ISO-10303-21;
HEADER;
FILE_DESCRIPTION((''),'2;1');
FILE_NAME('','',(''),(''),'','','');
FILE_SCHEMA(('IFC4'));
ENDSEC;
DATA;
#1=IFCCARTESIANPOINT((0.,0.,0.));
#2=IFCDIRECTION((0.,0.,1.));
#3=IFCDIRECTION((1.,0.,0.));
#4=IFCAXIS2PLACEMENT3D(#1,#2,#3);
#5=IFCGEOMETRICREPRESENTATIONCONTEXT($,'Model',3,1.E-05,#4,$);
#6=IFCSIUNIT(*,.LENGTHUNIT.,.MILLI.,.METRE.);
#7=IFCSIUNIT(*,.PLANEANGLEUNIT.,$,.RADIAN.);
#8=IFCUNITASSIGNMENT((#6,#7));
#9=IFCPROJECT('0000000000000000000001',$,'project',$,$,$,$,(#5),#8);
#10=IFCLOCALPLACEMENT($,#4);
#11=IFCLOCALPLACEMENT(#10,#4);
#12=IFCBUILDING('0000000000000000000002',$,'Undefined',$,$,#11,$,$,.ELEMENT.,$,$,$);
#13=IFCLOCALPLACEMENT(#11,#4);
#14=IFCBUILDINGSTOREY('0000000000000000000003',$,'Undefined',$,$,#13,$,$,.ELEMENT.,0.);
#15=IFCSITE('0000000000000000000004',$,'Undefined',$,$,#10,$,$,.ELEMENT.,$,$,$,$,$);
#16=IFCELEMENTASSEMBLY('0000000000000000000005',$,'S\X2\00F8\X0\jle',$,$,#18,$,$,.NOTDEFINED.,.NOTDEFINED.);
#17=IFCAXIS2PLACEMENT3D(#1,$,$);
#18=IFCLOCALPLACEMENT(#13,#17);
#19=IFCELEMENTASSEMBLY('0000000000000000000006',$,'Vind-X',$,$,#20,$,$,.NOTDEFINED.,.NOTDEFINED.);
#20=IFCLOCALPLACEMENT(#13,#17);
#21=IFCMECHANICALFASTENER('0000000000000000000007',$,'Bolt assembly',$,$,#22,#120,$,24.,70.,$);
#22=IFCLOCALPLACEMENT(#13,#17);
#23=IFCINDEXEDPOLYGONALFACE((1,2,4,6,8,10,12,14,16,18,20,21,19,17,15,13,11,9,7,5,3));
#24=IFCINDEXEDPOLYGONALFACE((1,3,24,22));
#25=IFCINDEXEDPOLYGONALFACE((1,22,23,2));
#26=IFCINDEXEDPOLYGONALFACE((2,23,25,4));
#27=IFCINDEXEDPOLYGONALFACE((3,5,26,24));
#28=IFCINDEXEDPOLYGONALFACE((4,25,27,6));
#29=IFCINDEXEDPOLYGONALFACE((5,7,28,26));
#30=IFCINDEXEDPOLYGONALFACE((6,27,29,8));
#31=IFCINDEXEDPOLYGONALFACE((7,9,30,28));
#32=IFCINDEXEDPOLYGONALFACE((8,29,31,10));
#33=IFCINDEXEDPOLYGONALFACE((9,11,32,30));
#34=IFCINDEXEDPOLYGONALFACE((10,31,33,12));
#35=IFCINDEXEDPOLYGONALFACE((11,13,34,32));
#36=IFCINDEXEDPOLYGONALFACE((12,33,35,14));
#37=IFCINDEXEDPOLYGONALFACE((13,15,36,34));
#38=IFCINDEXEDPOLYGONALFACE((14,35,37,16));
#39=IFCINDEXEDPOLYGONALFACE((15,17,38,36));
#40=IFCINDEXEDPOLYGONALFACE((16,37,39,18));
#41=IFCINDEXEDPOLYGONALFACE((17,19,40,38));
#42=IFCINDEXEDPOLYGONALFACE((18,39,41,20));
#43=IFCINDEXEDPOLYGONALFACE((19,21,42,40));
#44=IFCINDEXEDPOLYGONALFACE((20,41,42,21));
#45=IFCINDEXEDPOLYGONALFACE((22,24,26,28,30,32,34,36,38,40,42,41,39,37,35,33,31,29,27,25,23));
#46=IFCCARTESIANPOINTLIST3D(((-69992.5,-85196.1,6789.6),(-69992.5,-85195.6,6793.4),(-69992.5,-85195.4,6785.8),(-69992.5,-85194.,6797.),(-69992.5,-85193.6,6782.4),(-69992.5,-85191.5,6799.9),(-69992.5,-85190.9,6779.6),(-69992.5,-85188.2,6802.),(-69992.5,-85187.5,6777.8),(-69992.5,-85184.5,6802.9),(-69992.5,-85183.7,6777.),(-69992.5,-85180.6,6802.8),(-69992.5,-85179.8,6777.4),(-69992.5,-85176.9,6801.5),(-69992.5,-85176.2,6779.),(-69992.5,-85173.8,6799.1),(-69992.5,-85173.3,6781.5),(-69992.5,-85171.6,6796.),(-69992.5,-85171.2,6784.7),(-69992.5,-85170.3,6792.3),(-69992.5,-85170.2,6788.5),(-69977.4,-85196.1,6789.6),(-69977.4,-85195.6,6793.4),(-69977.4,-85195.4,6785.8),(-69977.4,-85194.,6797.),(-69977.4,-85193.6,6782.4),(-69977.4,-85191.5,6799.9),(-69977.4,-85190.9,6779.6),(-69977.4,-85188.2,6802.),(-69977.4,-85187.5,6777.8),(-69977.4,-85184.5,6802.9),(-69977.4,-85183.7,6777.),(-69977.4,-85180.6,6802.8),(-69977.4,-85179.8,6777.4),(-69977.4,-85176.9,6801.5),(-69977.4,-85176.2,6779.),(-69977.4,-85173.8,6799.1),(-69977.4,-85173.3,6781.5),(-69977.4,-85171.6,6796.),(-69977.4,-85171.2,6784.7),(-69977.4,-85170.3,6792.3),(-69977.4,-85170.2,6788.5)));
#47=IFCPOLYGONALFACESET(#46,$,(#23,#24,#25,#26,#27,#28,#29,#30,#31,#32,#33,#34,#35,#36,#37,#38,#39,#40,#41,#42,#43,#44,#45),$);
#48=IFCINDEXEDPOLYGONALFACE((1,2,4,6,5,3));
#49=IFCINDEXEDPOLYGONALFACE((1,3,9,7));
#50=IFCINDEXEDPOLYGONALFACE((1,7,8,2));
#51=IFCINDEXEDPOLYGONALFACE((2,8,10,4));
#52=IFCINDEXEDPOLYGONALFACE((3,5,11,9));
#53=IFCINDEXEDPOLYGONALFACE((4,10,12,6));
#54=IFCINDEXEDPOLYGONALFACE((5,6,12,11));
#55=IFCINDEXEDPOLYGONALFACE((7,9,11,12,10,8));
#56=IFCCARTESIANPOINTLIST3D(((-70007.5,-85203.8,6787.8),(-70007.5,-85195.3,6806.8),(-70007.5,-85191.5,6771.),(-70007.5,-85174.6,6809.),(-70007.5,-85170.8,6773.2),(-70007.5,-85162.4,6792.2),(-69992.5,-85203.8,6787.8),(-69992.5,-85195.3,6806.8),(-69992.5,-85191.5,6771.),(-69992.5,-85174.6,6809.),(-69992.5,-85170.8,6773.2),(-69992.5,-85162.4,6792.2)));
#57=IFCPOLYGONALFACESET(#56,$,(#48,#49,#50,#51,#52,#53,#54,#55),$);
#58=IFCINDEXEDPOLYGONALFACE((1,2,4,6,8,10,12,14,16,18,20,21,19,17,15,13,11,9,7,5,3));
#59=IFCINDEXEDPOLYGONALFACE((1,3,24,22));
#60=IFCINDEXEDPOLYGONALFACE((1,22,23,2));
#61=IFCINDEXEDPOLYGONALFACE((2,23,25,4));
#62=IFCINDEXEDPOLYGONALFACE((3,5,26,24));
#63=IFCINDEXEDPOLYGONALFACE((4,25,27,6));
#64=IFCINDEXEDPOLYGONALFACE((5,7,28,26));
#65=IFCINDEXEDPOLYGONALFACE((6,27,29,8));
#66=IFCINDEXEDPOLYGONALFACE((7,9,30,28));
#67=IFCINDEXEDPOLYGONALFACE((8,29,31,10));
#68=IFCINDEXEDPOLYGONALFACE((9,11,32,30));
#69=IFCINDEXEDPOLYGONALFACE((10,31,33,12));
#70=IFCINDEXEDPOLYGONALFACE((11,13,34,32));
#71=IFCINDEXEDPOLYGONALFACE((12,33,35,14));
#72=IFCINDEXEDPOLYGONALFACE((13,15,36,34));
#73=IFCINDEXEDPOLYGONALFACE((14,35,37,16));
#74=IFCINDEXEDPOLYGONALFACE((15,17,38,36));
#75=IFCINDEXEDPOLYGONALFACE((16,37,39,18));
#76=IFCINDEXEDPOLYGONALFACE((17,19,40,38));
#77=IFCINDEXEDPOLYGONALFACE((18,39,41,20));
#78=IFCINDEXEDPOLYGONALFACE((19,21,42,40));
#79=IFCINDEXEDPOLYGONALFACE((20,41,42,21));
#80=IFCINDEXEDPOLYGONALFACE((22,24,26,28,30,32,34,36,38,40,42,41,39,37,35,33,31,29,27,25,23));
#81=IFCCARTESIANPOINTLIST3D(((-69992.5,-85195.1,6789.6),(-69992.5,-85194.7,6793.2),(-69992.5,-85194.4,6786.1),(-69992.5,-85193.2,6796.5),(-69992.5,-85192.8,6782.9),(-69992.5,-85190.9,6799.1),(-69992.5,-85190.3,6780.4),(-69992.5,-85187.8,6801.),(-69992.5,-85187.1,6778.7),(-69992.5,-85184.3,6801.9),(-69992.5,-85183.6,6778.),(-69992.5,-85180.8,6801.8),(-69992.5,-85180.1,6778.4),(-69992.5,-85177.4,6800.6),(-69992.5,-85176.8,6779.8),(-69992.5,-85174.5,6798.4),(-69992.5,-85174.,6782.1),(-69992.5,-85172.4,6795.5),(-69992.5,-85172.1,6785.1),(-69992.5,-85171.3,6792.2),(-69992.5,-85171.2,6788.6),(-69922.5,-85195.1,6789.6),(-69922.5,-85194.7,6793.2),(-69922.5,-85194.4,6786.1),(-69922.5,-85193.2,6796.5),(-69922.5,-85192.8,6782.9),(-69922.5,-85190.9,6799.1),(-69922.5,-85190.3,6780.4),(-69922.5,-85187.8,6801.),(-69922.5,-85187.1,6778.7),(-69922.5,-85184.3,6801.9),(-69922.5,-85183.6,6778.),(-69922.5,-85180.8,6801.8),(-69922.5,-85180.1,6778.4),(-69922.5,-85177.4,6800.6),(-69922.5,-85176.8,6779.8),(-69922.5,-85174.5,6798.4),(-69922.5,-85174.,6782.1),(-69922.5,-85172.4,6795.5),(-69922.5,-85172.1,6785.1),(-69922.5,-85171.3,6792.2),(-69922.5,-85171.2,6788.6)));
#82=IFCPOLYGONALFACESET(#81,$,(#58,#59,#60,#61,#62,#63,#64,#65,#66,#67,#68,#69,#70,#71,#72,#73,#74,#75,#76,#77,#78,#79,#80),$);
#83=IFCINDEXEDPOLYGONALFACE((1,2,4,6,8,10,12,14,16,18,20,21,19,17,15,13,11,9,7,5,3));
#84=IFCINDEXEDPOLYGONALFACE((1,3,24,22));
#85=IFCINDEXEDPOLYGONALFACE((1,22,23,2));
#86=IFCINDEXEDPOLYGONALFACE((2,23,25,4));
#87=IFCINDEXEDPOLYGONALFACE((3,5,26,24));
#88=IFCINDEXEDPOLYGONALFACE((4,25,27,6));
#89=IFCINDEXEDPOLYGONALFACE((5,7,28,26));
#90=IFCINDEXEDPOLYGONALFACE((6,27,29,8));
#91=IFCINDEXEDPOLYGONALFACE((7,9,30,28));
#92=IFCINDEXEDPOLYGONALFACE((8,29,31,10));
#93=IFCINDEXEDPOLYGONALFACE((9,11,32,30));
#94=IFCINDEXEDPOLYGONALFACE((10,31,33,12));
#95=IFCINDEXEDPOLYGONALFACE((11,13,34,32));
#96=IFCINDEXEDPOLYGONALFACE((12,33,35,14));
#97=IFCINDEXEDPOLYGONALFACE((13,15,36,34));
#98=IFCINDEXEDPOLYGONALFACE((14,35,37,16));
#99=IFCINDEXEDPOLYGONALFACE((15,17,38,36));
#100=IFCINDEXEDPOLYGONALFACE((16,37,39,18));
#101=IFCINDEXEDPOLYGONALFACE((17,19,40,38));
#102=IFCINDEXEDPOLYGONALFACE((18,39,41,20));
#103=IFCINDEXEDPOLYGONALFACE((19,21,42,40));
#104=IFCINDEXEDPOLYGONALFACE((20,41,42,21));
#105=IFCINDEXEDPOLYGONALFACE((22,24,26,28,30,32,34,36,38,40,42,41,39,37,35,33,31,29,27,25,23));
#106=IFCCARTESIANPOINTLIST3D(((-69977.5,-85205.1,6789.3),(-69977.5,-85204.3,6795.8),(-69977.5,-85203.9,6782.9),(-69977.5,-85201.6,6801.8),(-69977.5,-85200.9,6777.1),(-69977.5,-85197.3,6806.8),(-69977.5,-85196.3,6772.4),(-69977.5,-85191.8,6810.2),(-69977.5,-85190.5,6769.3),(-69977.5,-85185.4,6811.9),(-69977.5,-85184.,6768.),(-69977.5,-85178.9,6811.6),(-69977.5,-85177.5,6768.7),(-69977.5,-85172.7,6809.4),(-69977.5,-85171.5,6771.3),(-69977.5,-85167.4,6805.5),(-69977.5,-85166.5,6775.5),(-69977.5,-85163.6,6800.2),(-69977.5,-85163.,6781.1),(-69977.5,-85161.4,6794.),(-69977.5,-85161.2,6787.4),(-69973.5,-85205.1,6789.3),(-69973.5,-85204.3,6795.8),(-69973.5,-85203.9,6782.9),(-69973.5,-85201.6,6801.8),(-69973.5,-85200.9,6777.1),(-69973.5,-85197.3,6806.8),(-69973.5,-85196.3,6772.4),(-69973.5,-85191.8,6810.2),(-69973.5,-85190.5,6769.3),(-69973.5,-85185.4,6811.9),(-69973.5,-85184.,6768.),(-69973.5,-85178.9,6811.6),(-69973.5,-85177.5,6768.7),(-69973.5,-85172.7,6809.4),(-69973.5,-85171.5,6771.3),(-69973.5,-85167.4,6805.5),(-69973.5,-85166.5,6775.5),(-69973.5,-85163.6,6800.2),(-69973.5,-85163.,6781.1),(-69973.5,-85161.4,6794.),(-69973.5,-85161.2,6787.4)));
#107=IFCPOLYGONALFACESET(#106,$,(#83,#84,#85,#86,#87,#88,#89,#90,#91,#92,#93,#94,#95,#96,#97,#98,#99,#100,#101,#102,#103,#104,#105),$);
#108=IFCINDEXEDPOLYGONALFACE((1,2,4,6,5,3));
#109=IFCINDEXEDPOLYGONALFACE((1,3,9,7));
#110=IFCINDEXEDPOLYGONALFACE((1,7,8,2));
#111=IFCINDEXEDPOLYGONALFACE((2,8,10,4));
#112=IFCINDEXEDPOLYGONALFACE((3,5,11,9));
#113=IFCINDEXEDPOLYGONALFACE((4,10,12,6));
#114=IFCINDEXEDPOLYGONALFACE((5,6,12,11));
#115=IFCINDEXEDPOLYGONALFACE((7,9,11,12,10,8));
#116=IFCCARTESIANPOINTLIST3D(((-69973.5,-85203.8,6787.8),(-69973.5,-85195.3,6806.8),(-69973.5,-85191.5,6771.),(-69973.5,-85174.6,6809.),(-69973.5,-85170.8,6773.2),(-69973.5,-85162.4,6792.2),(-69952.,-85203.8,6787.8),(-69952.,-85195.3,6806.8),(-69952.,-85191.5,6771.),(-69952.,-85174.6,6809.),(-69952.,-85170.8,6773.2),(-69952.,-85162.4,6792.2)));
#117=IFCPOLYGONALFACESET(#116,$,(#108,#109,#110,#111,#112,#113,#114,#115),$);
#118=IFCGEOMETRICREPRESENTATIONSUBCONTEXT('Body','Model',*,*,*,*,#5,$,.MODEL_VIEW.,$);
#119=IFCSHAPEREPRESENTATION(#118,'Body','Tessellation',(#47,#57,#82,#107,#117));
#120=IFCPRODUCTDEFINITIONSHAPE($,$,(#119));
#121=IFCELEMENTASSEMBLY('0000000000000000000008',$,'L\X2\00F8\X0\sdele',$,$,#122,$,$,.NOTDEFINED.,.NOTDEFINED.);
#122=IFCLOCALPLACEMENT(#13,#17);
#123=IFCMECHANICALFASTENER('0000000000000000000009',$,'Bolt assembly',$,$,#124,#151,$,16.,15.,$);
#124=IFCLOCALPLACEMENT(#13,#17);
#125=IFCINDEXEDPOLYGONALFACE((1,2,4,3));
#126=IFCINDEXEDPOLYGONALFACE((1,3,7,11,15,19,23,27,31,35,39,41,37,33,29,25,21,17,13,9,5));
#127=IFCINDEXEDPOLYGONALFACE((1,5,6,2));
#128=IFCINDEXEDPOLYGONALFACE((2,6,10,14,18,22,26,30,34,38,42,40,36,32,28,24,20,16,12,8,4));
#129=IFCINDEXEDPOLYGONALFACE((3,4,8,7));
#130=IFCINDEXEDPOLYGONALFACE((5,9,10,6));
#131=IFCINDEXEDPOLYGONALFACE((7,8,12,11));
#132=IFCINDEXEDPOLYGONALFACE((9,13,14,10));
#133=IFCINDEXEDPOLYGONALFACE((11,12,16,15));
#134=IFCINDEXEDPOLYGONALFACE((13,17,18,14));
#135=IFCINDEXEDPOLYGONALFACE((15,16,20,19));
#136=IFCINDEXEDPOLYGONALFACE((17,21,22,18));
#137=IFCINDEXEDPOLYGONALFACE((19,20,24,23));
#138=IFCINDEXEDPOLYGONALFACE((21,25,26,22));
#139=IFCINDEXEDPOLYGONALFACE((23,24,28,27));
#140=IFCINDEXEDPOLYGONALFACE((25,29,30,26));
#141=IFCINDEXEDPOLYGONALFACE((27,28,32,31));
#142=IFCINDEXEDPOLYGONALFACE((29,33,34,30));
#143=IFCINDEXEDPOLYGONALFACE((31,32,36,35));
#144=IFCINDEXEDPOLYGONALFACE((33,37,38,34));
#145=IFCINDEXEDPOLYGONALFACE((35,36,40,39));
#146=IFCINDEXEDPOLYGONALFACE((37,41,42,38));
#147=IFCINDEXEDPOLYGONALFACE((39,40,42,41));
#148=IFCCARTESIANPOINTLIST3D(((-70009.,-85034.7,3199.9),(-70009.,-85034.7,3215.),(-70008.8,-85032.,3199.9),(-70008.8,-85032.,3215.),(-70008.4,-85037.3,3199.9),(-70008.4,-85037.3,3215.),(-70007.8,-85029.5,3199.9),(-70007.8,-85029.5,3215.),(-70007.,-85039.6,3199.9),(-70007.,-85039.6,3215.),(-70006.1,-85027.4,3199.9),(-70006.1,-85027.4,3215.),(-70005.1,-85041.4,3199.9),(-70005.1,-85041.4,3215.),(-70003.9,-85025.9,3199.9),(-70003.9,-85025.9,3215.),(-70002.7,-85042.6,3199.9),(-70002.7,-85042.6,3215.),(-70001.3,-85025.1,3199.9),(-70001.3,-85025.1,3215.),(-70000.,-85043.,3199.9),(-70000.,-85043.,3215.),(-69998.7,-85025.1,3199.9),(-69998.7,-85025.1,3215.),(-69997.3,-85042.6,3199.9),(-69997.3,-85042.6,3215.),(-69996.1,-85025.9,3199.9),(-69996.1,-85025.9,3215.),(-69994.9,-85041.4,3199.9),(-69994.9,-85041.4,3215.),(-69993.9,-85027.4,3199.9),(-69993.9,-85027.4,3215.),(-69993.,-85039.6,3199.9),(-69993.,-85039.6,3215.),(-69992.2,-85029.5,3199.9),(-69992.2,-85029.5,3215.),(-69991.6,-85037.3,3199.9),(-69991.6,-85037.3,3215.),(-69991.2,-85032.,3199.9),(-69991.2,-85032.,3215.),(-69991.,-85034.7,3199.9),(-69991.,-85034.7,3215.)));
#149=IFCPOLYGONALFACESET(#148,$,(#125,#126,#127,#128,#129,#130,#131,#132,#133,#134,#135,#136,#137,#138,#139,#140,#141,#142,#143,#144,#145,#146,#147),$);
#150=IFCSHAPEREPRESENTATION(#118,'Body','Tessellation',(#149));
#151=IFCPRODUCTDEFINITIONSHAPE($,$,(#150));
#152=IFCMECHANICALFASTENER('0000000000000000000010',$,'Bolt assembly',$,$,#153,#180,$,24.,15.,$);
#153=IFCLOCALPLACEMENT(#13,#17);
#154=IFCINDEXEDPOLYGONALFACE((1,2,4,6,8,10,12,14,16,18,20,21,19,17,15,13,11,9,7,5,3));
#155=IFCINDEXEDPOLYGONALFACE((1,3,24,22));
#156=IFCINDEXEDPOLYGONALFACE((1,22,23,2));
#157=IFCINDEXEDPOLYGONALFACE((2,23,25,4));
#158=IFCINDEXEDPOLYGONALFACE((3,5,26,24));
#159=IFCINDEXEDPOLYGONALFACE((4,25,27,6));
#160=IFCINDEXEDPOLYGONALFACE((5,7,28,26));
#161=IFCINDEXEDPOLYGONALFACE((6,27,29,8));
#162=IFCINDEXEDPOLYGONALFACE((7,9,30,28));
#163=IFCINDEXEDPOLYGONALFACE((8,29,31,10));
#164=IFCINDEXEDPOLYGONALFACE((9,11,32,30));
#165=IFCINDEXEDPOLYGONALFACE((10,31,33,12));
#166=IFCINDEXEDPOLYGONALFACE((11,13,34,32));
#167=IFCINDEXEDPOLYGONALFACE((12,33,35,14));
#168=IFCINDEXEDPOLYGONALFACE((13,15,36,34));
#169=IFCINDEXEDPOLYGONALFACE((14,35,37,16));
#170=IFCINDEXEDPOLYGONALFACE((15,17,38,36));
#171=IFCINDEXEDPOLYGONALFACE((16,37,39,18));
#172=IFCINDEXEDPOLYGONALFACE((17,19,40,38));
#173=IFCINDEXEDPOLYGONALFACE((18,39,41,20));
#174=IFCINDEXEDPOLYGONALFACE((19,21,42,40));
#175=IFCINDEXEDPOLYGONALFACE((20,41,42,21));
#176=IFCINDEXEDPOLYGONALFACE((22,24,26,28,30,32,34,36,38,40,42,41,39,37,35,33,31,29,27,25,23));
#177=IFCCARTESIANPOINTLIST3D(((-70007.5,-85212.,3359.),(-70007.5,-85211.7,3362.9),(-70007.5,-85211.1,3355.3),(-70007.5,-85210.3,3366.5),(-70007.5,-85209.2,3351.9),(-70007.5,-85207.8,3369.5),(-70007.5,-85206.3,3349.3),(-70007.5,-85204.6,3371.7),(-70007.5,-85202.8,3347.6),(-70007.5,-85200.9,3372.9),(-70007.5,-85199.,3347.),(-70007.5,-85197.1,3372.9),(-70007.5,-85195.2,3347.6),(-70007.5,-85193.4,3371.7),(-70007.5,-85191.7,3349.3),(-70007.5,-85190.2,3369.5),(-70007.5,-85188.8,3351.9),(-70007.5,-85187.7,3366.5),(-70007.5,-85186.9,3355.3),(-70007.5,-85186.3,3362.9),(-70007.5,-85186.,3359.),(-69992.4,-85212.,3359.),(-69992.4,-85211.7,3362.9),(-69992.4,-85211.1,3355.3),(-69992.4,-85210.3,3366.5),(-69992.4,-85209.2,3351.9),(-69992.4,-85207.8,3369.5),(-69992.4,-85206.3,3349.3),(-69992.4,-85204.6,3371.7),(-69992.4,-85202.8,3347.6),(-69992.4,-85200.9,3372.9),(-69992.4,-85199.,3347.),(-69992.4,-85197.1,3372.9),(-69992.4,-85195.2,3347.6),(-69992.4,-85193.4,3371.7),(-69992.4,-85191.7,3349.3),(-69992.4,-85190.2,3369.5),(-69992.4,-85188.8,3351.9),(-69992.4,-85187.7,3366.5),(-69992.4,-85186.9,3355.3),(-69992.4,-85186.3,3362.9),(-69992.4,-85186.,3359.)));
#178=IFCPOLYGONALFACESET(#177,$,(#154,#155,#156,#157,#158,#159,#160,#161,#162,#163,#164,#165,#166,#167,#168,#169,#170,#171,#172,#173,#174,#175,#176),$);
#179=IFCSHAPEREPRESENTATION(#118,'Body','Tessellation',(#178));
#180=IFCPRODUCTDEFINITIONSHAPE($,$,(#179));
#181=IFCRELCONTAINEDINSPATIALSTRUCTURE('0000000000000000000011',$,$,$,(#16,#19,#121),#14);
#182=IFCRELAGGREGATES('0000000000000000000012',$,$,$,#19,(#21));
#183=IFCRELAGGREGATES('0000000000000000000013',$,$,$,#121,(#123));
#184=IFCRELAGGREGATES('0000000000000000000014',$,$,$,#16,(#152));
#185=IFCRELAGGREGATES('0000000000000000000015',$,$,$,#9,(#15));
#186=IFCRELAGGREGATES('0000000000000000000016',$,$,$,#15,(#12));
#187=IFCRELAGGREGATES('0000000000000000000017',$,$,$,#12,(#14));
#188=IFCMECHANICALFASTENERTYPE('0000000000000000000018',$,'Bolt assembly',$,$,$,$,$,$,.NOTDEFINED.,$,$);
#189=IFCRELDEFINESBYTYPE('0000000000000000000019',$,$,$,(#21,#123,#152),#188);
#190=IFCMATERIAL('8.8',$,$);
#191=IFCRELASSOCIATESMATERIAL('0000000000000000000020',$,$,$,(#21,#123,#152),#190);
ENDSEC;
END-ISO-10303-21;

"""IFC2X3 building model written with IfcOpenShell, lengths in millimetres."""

from ifc_helpers import new_model, si_unit, frame, origin_with_axes, origin_2d_with_axis, place, context, subcontext, project, spatial, polyline, circle, outline, extrude, source, transform, mapped, material, type_object, element, aggregate, save


model = new_model("IFC2X3")

# Units and contexts
model_context = context("Model", 3, precision=1e-05, world=origin_with_axes())
body_context = subcontext(model_context, "Body", "Model", "MODEL_VIEW")
ifc_project = project(units=[si_unit("LENGTHUNIT", "METRE", prefix="MILLI"), si_unit("PLANEANGLEUNIT", "RADIAN")], contexts=[model_context])

# Site, building, storey
site_placement = place(None, origin_with_axes())
site = spatial("IfcSite", under=ifc_project, at=site_placement, Name="Undefined", CompositionType="ELEMENT")
building_placement = place(site_placement, origin_with_axes())
building = spatial("IfcBuilding", under=site, at=building_placement, Name="Undefined", CompositionType="ELEMENT")
storey_placement = place(building_placement, origin_with_axes())
storey = spatial("IfcBuildingStorey", under=building, at=storey_placement, Name="Undefined", CompositionType="ELEMENT", Elevation=0.0)

# Element assembly
assembly_1_placement = place(storey_placement, origin_with_axes())
assembly_1 = element("IfcElementAssembly", 1, at=assembly_1_placement, inside=storey, Name="Søjle", AssemblyPlace="NOTDEFINED", PredefinedType="NOTDEFINED")

# Element assembly
assembly_2_placement = place(storey_placement, origin_with_axes())
assembly_2 = element("IfcElementAssembly", 2, at=assembly_2_placement, inside=storey, Name="Vind-X", AssemblyPlace="NOTDEFINED", PredefinedType="NOTDEFINED")

# Mechanical fastener
ifc_material_1 = material(Name="8.8")
mechanical_fastener_type = type_object("IfcMechanicalFastenerType", Name="Bolt assembly")
shared_shape_1 = source(origin_with_axes(), body_context, "Body", "SweptSolid", [
    extrude(circle(Radius=13.0, at=origin_2d_with_axis()), frame((0.0, 0.0, 0.0), z_axis=(0.0, 1.0, 0.0), x_axis=(1.0, 0.0, 0.0)), (0.0, 0.0, 1.0), 15.1),
    extrude(outline(polyline([(18.0, -10.4), (18.0, 10.4), (0.0, 20.8), (-18.0, 10.4), (-18.0, -10.4), (0.0, -20.8), (18.0, -10.4)])), frame((0.0, -15.0, 0.0), z_axis=(0.0, 1.0, 0.0), x_axis=(1.0, 0.0, 0.0)), (0.0, 0.0, 1.0), 15.0),
    extrude(circle(Radius=12.0, at=origin_2d_with_axis()), frame((0.0, 0.0, 0.0), z_axis=(0.0, 1.0, 0.0), x_axis=(1.0, 0.0, 0.0)), (0.0, 0.0, 1.0), 70.0),
    extrude(circle(Radius=22.0, at=origin_2d_with_axis()), frame((0.0, 15.0, 0.0), z_axis=(0.0, 1.0, 0.0), x_axis=(1.0, 0.0, 0.0)), (0.0, 0.0, 1.0), 4.0),
    extrude(outline(polyline([(18.0, -10.4), (18.0, 10.4), (0.0, 20.8), (-18.0, 10.4), (-18.0, -10.4), (0.0, -20.8), (18.0, -10.4)])), frame((0.0, 19.0, 0.0), z_axis=(0.0, 1.0, 0.0), x_axis=(1.0, 0.0, 0.0)), (0.0, 0.0, 1.0), 21.5),
])
mechanical_fastener_1_placement = place(assembly_2_placement, frame((-69992.5, -85183.1, 6790.0), z_axis=(0.0, -0.588616, 0.808413), x_axis=(0.0, -0.808413, -0.588616)))
mechanical_fastener_1 = element("IfcMechanicalFastener", 3, at=mechanical_fastener_1_placement, type_object=mechanical_fastener_type, material=ifc_material_1, Name="Bolt assembly", NominalDiameter=24.0, NominalLength=70.0, context=body_context, shape_type="MappedRepresentation", body=[
    mapped(shared_shape_1, transform((0.0, 0.0, 0.0))),
])
aggregate(assembly_2, [mechanical_fastener_1])

# Element assembly, mechanical fastener
assembly_3_placement = place(storey_placement, origin_with_axes())
assembly_3 = element("IfcElementAssembly", 4, at=assembly_3_placement, inside=storey, Name="Løsdele", AssemblyPlace="NOTDEFINED", PredefinedType="NOTDEFINED")
shared_shape_2 = source(origin_with_axes(), body_context, "Body", "SweptSolid", [
    extrude(circle(Radius=9.0, at=origin_2d_with_axis()), frame((0.0, -15.0, 0.0), z_axis=(0.0, 1.0, 0.0), x_axis=(1.0, 0.0, 0.0)), (0.0, 0.0, 1.0), 15.1),
])
mechanical_fastener_2_placement = place(assembly_3_placement, frame((-70000.0, -85034.0, 3200.0), z_axis=(1.0, -0.000002, 0.0), x_axis=(-0.000002, -1.0, 0.0)))
mechanical_fastener_2 = element("IfcMechanicalFastener", 5, at=mechanical_fastener_2_placement, type_object=mechanical_fastener_type, material=ifc_material_1, Name="Bolt assembly", NominalDiameter=16.0, NominalLength=15.0, context=body_context, shape_type="MappedRepresentation", body=[
    mapped(shared_shape_2, transform((0.0, 0.0, 0.0))),
])
aggregate(assembly_3, [mechanical_fastener_2])

# Mechanical fastener
shared_shape_3 = source(origin_with_axes(), body_context, "Body", "SweptSolid", [
    extrude(circle(Radius=13.0, at=origin_2d_with_axis()), frame((0.0, -7.5, 0.0), z_axis=(0.0, 1.0, 0.0), x_axis=(1.0, 0.0, 0.0)), (0.0, 0.0, 1.0), 15.1),
])
mechanical_fastener_3_placement = place(assembly_1_placement, frame((-70000.0, -85199.0, 3360.0), z_axis=(0.0, -1.0, 0.0), x_axis=(0.0, 0.0, -1.0)))
mechanical_fastener_3 = element("IfcMechanicalFastener", 6, at=mechanical_fastener_3_placement, type_object=mechanical_fastener_type, material=ifc_material_1, Name="Bolt assembly", NominalDiameter=24.0, NominalLength=15.0, context=body_context, shape_type="MappedRepresentation", body=[
    mapped(shared_shape_3, transform((0.0, 0.0, 0.0))),
])
aggregate(assembly_1, [mechanical_fastener_3])

save(model, "model.ifc")
